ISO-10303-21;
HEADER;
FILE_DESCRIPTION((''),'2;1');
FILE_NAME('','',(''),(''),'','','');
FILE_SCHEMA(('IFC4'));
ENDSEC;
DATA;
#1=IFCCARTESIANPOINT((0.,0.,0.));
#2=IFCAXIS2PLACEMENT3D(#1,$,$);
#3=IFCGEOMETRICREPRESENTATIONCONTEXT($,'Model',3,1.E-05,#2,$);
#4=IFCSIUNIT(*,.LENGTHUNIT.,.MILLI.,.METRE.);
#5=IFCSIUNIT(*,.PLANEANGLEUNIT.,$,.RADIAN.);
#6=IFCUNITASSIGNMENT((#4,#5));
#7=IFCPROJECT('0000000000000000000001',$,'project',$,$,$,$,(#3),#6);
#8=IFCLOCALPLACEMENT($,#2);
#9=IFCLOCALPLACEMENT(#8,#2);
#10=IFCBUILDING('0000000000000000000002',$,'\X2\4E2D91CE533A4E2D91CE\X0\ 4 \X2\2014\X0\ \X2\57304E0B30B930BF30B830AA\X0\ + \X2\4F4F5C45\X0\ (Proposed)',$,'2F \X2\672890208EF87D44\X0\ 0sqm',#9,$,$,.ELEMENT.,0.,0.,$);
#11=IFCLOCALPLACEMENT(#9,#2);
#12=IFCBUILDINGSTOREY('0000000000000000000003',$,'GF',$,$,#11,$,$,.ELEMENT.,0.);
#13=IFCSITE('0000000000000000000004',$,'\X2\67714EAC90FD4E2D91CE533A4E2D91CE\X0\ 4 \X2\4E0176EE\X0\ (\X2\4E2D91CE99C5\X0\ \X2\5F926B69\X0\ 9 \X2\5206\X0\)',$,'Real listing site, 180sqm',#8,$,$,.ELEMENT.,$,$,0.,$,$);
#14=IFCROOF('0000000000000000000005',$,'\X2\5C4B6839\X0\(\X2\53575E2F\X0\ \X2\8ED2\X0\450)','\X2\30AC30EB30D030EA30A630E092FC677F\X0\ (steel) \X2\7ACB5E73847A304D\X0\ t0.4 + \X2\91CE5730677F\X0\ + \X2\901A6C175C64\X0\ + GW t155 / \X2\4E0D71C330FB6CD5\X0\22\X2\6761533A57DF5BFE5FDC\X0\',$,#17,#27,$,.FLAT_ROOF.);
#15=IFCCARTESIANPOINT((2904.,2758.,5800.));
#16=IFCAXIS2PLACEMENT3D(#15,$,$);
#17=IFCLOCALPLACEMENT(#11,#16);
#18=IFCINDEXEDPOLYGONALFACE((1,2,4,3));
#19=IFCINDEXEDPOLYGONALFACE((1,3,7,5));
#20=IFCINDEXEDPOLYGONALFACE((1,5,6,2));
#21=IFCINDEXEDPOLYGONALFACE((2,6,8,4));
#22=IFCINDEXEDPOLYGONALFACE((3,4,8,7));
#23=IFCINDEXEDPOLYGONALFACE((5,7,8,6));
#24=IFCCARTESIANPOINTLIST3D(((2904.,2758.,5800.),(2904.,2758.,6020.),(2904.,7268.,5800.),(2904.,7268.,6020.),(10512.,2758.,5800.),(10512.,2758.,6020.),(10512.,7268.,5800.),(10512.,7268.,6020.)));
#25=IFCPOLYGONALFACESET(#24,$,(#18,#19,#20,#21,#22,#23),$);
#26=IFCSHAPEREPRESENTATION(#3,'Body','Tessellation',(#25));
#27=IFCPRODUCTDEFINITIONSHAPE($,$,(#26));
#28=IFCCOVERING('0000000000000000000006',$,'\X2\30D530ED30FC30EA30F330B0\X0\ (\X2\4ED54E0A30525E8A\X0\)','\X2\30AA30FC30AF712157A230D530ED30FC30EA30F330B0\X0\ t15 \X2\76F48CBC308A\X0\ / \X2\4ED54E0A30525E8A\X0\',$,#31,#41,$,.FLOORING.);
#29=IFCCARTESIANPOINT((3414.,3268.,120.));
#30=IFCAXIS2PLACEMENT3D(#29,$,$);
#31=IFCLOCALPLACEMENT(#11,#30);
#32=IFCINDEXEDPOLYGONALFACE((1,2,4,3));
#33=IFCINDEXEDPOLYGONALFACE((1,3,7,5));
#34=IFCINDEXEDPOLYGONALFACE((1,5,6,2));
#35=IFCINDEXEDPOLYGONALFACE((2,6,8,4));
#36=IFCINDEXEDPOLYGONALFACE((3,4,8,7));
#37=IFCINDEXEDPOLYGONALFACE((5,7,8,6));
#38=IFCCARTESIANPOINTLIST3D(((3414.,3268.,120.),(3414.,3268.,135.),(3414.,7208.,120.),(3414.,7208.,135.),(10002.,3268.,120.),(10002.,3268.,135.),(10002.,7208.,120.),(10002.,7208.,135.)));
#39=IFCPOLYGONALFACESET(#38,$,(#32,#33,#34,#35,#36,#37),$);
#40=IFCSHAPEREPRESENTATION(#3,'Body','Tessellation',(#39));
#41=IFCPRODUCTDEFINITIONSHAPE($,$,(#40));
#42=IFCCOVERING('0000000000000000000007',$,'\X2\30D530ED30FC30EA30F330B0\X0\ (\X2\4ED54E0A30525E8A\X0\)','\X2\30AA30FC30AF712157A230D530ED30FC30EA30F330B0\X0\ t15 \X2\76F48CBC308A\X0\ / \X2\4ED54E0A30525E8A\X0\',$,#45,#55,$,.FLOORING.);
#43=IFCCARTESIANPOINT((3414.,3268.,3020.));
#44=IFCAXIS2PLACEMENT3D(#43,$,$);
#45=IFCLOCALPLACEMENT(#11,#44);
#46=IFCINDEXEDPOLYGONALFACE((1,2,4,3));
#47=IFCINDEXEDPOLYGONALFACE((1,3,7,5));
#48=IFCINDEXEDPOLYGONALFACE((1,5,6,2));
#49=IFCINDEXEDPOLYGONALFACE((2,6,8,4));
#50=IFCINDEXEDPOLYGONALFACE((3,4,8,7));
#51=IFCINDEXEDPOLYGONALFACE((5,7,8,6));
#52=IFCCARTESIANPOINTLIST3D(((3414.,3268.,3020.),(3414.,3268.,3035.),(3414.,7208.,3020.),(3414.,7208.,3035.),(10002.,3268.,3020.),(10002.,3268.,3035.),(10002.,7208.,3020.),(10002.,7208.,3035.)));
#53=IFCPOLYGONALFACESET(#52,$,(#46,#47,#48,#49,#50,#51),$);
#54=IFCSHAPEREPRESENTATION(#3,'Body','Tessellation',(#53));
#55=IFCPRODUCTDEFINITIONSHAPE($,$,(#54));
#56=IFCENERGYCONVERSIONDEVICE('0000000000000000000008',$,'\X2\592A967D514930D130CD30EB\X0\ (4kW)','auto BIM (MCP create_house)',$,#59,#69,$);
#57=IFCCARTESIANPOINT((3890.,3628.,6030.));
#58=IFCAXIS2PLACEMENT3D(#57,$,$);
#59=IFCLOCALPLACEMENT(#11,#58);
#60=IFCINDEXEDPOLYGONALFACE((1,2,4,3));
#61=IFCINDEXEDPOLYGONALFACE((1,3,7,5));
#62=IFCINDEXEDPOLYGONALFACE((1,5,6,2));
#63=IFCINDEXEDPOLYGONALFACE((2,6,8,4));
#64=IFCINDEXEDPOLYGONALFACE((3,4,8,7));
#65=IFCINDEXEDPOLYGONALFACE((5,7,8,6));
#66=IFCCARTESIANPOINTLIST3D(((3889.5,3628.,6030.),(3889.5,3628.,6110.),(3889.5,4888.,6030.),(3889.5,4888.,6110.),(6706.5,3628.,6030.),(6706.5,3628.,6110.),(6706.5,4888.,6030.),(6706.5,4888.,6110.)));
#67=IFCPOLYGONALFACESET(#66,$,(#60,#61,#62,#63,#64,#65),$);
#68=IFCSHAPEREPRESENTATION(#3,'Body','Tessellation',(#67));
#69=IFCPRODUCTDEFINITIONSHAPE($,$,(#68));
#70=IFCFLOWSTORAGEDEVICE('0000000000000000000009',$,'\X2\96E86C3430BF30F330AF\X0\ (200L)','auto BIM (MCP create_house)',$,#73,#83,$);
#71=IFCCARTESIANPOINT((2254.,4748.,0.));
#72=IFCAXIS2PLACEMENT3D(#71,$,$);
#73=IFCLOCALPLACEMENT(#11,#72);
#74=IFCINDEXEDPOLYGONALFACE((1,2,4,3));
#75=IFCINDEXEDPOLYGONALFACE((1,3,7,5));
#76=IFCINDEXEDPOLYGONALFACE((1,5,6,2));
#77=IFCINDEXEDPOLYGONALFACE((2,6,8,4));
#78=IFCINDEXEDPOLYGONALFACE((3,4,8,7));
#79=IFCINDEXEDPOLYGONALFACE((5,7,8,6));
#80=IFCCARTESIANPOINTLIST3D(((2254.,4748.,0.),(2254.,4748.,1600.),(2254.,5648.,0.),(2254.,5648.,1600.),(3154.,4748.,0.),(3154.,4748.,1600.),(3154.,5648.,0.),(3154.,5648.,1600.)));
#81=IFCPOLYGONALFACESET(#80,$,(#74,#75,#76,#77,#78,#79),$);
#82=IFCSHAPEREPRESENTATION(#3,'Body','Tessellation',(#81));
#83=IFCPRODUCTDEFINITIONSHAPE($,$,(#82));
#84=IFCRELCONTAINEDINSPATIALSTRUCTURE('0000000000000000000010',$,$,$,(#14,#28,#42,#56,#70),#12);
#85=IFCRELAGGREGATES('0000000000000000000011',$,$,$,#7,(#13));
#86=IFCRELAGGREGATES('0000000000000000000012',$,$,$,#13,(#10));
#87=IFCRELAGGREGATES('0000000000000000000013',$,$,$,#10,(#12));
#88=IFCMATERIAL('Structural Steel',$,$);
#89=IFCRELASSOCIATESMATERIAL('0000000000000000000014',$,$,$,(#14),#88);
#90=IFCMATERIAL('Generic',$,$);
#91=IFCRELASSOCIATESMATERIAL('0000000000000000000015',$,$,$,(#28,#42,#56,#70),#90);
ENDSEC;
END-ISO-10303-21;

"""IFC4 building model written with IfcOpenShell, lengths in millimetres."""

from ifc_helpers import new_model, si_unit, frame, frame_2d, origin, place, context, project, spatial, rectangle, extrude, material, element, save


model = new_model("IFC4")

# Units and contexts
model_context = context("Model", 3, precision=1e-05, world=origin())
ifc_project = project(units=[si_unit("LENGTHUNIT", "METRE", prefix="MILLI"), si_unit("PLANEANGLEUNIT", "RADIAN")], contexts=[model_context])

# Site, building, storey
site_placement = place(None, origin())
site = spatial("IfcSite", under=ifc_project, at=site_placement, Name="東京都中野区中野 4 丁目 (中野駅 徒歩 9 分)", ObjectType="Real listing site, 180sqm", CompositionType="ELEMENT", RefElevation=0.0)
building_placement = place(site_placement, origin())
building = spatial("IfcBuilding", under=site, at=building_placement, Name="中野区中野 4 — 地下スタジオ + 住居 (Proposed)", ObjectType="2F 木造軸組 0sqm", CompositionType="ELEMENT", ElevationOfRefHeight=0.0, ElevationOfTerrain=0.0)
storey_placement = place(building_placement, origin())
storey = spatial("IfcBuildingStorey", under=building, at=storey_placement, Name="GF", CompositionType="ELEMENT", Elevation=0.0)

# Roof
ifc_material_1 = material(Name="Structural Steel")
for number, where, name in (
    (1, (2904.0, 2758.0, 5800.0), "屋根(南帯 軒450)"),
):
    element("IfcRoof", number, at=place(storey_placement, frame(where)), inside=storey, material=ifc_material_1, Name=name, Description="ガルバリウム鋼板 (steel) 立平葺き t0.4 + 野地板 + 通気層 + GW t155 / 不燃・法22条区域対応", PredefinedType="FLAT_ROOF", context=model_context, shape_type="SweptSolid", body=[
        extrude(rectangle(XDim=7608.0, YDim=4510.0, at=frame_2d((3804.0, 2255.0))), frame((2904.0, 2758.0, 5800.0)), (0.0, 0.0, 1.0), 220.0),
    ])

# Coverings
ifc_material_2 = material(Name="Generic")
covering_1_placement = place(storey_placement, frame((3414.0, 3268.0, 120.0)))
element("IfcCovering", 2, at=covering_1_placement, inside=storey, material=ifc_material_2, Name="フローリング (仕上げ床)", Description="オーク無垢フローリング t15 直貼り / 仕上げ床", PredefinedType="FLOORING", context=model_context, shape_type="SweptSolid", body=[
    extrude(rectangle(XDim=6588.0, YDim=3940.0, at=frame_2d((3294.0, 1970.0))), frame((3414.0, 3268.0, 120.0)), (0.0, 0.0, 1.0), 15.0),
])
covering_2_placement = place(storey_placement, frame((3414.0, 3268.0, 3020.0)))
element("IfcCovering", 3, at=covering_2_placement, inside=storey, material=ifc_material_2, Name="フローリング (仕上げ床)", Description="オーク無垢フローリング t15 直貼り / 仕上げ床", PredefinedType="FLOORING", context=model_context, shape_type="SweptSolid", body=[
    extrude(rectangle(XDim=6588.0, YDim=3940.0, at=frame_2d((3294.0, 1970.0))), frame((3414.0, 3268.0, 3020.0)), (0.0, 0.0, 1.0), 15.0),
])

# Energy conversion device
energy_conversion_device_placement = place(storey_placement, frame((3890.0, 3628.0, 6030.0)))
element("IfcEnergyConversionDevice", 4, at=energy_conversion_device_placement, inside=storey, material=ifc_material_2, Name="太陽光パネル (4kW)", Description="auto BIM (MCP create_house)", context=model_context, shape_type="SweptSolid", body=[
    extrude(rectangle(XDim=2817.0, YDim=1260.0, at=frame_2d((1408.0, 630.0))), frame((3890.0, 3628.0, 6030.0)), (0.0, 0.0, 1.0), 80.0),
])

# Flow storage device
flow_storage_device_placement = place(storey_placement, frame((2254.0, 4748.0, 0.0)))
element("IfcFlowStorageDevice", 5, at=flow_storage_device_placement, inside=storey, material=ifc_material_2, Name="雨水タンク (200L)", Description="auto BIM (MCP create_house)", context=model_context, shape_type="SweptSolid", body=[
    extrude(rectangle(XDim=900.0, YDim=900.0, at=frame_2d((450.0, 450.0))), frame((2254.0, 4748.0, 0.0)), (0.0, 0.0, 1.0), 1600.0),
])

save(model, "model.ifc")
